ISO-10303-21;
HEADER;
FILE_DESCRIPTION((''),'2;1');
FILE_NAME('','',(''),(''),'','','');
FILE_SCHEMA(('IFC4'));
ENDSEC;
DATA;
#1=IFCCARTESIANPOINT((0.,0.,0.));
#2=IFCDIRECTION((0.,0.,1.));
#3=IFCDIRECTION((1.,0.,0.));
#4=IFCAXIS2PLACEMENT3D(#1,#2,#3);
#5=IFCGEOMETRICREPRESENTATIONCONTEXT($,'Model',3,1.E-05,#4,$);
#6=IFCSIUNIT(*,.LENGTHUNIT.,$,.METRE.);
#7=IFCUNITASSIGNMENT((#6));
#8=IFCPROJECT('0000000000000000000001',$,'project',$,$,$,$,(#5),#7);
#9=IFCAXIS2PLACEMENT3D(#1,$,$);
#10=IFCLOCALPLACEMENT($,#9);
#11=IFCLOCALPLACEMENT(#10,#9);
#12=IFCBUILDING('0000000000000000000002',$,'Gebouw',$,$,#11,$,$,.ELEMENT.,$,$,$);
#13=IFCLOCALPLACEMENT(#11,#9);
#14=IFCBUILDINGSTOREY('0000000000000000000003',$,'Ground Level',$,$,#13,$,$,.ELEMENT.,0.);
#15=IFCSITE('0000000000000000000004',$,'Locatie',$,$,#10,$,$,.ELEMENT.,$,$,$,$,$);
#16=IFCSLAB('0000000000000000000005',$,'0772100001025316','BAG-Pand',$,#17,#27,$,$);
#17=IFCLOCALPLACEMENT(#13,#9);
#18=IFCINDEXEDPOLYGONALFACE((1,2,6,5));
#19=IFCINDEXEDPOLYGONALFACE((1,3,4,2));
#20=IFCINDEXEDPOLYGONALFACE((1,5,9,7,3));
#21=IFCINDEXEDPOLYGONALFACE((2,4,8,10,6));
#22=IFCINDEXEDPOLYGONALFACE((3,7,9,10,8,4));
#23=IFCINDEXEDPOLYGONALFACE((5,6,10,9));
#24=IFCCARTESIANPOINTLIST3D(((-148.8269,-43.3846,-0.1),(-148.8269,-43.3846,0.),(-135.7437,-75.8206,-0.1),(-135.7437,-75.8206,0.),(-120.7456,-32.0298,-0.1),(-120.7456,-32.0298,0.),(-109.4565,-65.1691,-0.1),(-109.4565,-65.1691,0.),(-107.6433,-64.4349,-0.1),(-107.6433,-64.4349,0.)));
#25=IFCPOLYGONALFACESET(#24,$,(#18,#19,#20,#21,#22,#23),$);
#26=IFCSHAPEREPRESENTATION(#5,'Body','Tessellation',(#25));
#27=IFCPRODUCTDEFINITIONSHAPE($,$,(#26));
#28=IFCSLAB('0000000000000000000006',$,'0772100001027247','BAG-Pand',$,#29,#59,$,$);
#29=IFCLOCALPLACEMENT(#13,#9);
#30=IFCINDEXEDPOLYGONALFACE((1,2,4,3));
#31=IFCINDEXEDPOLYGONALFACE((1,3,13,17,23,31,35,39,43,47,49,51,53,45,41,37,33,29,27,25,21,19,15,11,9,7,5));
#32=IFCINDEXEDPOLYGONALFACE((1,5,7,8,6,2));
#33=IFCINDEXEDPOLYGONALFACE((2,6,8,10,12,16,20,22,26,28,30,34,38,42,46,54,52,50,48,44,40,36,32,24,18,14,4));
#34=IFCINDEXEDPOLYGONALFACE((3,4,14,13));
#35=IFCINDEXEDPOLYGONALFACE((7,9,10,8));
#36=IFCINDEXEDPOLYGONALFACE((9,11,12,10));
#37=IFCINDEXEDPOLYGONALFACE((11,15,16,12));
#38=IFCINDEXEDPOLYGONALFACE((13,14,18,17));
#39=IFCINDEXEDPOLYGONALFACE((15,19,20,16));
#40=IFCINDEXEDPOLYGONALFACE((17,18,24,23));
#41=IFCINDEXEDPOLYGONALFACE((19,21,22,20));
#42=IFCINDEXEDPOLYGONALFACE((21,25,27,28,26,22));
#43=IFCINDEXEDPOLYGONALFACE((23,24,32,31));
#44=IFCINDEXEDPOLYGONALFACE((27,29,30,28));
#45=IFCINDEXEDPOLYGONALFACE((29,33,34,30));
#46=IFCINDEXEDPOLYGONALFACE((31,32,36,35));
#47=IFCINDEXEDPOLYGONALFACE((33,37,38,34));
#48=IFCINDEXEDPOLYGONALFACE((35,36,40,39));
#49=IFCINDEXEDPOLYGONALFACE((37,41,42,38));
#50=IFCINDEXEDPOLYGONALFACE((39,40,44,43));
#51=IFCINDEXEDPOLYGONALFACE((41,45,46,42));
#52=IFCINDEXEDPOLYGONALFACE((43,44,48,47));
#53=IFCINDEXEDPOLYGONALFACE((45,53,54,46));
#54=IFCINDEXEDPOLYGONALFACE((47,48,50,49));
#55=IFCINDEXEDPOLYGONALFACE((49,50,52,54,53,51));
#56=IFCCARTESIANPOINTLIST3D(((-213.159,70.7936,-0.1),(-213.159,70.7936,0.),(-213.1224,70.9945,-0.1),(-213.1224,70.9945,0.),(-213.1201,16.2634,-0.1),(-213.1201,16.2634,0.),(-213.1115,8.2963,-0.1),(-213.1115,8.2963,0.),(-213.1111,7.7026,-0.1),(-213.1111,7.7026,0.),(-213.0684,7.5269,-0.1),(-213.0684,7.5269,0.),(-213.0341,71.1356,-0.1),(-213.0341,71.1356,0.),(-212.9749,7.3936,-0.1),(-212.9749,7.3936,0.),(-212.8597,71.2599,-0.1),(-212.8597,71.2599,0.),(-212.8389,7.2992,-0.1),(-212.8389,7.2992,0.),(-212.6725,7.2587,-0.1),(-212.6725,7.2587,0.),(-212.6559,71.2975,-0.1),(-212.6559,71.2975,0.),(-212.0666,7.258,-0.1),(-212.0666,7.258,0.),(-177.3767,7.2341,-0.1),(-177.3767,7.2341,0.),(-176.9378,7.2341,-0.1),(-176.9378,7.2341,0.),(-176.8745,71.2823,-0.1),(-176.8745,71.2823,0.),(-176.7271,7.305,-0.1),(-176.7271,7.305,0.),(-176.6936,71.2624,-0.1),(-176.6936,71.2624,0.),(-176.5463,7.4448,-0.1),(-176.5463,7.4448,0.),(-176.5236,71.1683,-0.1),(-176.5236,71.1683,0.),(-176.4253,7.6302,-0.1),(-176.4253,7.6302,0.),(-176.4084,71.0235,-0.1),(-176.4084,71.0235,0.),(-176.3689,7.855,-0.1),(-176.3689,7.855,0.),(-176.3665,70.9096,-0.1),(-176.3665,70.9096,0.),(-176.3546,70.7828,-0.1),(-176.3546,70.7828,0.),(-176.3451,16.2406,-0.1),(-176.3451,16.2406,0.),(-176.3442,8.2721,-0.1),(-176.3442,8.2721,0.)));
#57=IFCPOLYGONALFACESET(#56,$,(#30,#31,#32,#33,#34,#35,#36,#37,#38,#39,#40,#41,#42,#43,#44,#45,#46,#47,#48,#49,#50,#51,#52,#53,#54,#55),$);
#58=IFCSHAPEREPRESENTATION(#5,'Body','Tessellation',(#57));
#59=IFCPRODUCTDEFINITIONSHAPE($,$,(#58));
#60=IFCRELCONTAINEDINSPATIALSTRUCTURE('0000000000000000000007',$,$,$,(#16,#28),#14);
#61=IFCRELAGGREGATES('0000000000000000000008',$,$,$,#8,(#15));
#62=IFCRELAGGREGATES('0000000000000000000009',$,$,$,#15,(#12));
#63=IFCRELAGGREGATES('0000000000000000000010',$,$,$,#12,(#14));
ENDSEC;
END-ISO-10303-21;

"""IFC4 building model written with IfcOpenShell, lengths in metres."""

from ifc_helpers import new_model, si_unit, frame, origin, origin_with_axes, place, context, project, spatial, polyline, outline, extrude, element, save


model = new_model("IFC4")

# Units and contexts
model_context = context("Model", 3, precision=1e-05, world=origin_with_axes())
ifc_project = project(units=[si_unit("LENGTHUNIT", "METRE")], contexts=[model_context])

# Site, building, storey
site_placement = place(None, origin())
site = spatial("IfcSite", under=ifc_project, at=site_placement, Name="Locatie", CompositionType="ELEMENT")
building_placement = place(site_placement, origin())
building = spatial("IfcBuilding", under=site, at=building_placement, Name="Gebouw", CompositionType="ELEMENT")
storey_placement = place(building_placement, origin())
storey = spatial("IfcBuildingStorey", under=building, at=storey_placement, Name="Ground Level", CompositionType="ELEMENT", Elevation=0.0)

# Slabs
slab_1_placement = place(storey_placement, origin())
element("IfcSlab", 1, at=slab_1_placement, inside=storey, Name="0772100001025316", Description="BAG-Pand", context=model_context, shape_type="SweptSolid", body=[
    extrude(outline(polyline([(-148.8269, -43.3846), (-120.7456, -32.0298), (-107.6433, -64.4349), (-109.4565, -65.1691), (-135.7437, -75.8206), (-148.8269, -43.3846)])), frame((0.0, 0.0, -0.1), z_axis=(0.0, 0.0, 1.0), x_axis=(1.0, 0.0, 0.0)), (0.0, 0.0, 1.0), 0.1),
])
slab_2_placement = place(storey_placement, origin())
element("IfcSlab", 2, at=slab_2_placement, inside=storey, Name="0772100001027247", Description="BAG-Pand", context=model_context, shape_type="SweptSolid", body=[
    extrude(outline(polyline([(-213.0684, 7.5269), (-213.1111, 7.7026), (-213.1115, 8.2963), (-213.1201, 16.2634), (-213.159, 70.7936), (-213.1224, 70.9945), (-213.0341, 71.1356), (-212.8597, 71.2599), (-212.6559, 71.2975), (-176.8745, 71.2823), (-176.6936, 71.2624), (-176.5236, 71.1683), (-176.4084, 71.0235), (-176.3665, 70.9096), (-176.3546, 70.7828), (-176.3451, 16.2406), (-176.3442, 8.2721), (-176.3689, 7.855), (-176.4253, 7.6302), (-176.5463, 7.4448), (-176.7271, 7.305), (-176.9378, 7.2341), (-177.3767, 7.2341), (-212.0666, 7.258), (-212.6725, 7.2587), (-212.8389, 7.2992), (-212.9749, 7.3936), (-213.0684, 7.5269)])), frame((0.0, 0.0, -0.1), z_axis=(0.0, 0.0, 1.0), x_axis=(1.0, 0.0, 0.0)), (0.0, 0.0, 1.0), 0.1),
])

save(model, "model.ifc")
